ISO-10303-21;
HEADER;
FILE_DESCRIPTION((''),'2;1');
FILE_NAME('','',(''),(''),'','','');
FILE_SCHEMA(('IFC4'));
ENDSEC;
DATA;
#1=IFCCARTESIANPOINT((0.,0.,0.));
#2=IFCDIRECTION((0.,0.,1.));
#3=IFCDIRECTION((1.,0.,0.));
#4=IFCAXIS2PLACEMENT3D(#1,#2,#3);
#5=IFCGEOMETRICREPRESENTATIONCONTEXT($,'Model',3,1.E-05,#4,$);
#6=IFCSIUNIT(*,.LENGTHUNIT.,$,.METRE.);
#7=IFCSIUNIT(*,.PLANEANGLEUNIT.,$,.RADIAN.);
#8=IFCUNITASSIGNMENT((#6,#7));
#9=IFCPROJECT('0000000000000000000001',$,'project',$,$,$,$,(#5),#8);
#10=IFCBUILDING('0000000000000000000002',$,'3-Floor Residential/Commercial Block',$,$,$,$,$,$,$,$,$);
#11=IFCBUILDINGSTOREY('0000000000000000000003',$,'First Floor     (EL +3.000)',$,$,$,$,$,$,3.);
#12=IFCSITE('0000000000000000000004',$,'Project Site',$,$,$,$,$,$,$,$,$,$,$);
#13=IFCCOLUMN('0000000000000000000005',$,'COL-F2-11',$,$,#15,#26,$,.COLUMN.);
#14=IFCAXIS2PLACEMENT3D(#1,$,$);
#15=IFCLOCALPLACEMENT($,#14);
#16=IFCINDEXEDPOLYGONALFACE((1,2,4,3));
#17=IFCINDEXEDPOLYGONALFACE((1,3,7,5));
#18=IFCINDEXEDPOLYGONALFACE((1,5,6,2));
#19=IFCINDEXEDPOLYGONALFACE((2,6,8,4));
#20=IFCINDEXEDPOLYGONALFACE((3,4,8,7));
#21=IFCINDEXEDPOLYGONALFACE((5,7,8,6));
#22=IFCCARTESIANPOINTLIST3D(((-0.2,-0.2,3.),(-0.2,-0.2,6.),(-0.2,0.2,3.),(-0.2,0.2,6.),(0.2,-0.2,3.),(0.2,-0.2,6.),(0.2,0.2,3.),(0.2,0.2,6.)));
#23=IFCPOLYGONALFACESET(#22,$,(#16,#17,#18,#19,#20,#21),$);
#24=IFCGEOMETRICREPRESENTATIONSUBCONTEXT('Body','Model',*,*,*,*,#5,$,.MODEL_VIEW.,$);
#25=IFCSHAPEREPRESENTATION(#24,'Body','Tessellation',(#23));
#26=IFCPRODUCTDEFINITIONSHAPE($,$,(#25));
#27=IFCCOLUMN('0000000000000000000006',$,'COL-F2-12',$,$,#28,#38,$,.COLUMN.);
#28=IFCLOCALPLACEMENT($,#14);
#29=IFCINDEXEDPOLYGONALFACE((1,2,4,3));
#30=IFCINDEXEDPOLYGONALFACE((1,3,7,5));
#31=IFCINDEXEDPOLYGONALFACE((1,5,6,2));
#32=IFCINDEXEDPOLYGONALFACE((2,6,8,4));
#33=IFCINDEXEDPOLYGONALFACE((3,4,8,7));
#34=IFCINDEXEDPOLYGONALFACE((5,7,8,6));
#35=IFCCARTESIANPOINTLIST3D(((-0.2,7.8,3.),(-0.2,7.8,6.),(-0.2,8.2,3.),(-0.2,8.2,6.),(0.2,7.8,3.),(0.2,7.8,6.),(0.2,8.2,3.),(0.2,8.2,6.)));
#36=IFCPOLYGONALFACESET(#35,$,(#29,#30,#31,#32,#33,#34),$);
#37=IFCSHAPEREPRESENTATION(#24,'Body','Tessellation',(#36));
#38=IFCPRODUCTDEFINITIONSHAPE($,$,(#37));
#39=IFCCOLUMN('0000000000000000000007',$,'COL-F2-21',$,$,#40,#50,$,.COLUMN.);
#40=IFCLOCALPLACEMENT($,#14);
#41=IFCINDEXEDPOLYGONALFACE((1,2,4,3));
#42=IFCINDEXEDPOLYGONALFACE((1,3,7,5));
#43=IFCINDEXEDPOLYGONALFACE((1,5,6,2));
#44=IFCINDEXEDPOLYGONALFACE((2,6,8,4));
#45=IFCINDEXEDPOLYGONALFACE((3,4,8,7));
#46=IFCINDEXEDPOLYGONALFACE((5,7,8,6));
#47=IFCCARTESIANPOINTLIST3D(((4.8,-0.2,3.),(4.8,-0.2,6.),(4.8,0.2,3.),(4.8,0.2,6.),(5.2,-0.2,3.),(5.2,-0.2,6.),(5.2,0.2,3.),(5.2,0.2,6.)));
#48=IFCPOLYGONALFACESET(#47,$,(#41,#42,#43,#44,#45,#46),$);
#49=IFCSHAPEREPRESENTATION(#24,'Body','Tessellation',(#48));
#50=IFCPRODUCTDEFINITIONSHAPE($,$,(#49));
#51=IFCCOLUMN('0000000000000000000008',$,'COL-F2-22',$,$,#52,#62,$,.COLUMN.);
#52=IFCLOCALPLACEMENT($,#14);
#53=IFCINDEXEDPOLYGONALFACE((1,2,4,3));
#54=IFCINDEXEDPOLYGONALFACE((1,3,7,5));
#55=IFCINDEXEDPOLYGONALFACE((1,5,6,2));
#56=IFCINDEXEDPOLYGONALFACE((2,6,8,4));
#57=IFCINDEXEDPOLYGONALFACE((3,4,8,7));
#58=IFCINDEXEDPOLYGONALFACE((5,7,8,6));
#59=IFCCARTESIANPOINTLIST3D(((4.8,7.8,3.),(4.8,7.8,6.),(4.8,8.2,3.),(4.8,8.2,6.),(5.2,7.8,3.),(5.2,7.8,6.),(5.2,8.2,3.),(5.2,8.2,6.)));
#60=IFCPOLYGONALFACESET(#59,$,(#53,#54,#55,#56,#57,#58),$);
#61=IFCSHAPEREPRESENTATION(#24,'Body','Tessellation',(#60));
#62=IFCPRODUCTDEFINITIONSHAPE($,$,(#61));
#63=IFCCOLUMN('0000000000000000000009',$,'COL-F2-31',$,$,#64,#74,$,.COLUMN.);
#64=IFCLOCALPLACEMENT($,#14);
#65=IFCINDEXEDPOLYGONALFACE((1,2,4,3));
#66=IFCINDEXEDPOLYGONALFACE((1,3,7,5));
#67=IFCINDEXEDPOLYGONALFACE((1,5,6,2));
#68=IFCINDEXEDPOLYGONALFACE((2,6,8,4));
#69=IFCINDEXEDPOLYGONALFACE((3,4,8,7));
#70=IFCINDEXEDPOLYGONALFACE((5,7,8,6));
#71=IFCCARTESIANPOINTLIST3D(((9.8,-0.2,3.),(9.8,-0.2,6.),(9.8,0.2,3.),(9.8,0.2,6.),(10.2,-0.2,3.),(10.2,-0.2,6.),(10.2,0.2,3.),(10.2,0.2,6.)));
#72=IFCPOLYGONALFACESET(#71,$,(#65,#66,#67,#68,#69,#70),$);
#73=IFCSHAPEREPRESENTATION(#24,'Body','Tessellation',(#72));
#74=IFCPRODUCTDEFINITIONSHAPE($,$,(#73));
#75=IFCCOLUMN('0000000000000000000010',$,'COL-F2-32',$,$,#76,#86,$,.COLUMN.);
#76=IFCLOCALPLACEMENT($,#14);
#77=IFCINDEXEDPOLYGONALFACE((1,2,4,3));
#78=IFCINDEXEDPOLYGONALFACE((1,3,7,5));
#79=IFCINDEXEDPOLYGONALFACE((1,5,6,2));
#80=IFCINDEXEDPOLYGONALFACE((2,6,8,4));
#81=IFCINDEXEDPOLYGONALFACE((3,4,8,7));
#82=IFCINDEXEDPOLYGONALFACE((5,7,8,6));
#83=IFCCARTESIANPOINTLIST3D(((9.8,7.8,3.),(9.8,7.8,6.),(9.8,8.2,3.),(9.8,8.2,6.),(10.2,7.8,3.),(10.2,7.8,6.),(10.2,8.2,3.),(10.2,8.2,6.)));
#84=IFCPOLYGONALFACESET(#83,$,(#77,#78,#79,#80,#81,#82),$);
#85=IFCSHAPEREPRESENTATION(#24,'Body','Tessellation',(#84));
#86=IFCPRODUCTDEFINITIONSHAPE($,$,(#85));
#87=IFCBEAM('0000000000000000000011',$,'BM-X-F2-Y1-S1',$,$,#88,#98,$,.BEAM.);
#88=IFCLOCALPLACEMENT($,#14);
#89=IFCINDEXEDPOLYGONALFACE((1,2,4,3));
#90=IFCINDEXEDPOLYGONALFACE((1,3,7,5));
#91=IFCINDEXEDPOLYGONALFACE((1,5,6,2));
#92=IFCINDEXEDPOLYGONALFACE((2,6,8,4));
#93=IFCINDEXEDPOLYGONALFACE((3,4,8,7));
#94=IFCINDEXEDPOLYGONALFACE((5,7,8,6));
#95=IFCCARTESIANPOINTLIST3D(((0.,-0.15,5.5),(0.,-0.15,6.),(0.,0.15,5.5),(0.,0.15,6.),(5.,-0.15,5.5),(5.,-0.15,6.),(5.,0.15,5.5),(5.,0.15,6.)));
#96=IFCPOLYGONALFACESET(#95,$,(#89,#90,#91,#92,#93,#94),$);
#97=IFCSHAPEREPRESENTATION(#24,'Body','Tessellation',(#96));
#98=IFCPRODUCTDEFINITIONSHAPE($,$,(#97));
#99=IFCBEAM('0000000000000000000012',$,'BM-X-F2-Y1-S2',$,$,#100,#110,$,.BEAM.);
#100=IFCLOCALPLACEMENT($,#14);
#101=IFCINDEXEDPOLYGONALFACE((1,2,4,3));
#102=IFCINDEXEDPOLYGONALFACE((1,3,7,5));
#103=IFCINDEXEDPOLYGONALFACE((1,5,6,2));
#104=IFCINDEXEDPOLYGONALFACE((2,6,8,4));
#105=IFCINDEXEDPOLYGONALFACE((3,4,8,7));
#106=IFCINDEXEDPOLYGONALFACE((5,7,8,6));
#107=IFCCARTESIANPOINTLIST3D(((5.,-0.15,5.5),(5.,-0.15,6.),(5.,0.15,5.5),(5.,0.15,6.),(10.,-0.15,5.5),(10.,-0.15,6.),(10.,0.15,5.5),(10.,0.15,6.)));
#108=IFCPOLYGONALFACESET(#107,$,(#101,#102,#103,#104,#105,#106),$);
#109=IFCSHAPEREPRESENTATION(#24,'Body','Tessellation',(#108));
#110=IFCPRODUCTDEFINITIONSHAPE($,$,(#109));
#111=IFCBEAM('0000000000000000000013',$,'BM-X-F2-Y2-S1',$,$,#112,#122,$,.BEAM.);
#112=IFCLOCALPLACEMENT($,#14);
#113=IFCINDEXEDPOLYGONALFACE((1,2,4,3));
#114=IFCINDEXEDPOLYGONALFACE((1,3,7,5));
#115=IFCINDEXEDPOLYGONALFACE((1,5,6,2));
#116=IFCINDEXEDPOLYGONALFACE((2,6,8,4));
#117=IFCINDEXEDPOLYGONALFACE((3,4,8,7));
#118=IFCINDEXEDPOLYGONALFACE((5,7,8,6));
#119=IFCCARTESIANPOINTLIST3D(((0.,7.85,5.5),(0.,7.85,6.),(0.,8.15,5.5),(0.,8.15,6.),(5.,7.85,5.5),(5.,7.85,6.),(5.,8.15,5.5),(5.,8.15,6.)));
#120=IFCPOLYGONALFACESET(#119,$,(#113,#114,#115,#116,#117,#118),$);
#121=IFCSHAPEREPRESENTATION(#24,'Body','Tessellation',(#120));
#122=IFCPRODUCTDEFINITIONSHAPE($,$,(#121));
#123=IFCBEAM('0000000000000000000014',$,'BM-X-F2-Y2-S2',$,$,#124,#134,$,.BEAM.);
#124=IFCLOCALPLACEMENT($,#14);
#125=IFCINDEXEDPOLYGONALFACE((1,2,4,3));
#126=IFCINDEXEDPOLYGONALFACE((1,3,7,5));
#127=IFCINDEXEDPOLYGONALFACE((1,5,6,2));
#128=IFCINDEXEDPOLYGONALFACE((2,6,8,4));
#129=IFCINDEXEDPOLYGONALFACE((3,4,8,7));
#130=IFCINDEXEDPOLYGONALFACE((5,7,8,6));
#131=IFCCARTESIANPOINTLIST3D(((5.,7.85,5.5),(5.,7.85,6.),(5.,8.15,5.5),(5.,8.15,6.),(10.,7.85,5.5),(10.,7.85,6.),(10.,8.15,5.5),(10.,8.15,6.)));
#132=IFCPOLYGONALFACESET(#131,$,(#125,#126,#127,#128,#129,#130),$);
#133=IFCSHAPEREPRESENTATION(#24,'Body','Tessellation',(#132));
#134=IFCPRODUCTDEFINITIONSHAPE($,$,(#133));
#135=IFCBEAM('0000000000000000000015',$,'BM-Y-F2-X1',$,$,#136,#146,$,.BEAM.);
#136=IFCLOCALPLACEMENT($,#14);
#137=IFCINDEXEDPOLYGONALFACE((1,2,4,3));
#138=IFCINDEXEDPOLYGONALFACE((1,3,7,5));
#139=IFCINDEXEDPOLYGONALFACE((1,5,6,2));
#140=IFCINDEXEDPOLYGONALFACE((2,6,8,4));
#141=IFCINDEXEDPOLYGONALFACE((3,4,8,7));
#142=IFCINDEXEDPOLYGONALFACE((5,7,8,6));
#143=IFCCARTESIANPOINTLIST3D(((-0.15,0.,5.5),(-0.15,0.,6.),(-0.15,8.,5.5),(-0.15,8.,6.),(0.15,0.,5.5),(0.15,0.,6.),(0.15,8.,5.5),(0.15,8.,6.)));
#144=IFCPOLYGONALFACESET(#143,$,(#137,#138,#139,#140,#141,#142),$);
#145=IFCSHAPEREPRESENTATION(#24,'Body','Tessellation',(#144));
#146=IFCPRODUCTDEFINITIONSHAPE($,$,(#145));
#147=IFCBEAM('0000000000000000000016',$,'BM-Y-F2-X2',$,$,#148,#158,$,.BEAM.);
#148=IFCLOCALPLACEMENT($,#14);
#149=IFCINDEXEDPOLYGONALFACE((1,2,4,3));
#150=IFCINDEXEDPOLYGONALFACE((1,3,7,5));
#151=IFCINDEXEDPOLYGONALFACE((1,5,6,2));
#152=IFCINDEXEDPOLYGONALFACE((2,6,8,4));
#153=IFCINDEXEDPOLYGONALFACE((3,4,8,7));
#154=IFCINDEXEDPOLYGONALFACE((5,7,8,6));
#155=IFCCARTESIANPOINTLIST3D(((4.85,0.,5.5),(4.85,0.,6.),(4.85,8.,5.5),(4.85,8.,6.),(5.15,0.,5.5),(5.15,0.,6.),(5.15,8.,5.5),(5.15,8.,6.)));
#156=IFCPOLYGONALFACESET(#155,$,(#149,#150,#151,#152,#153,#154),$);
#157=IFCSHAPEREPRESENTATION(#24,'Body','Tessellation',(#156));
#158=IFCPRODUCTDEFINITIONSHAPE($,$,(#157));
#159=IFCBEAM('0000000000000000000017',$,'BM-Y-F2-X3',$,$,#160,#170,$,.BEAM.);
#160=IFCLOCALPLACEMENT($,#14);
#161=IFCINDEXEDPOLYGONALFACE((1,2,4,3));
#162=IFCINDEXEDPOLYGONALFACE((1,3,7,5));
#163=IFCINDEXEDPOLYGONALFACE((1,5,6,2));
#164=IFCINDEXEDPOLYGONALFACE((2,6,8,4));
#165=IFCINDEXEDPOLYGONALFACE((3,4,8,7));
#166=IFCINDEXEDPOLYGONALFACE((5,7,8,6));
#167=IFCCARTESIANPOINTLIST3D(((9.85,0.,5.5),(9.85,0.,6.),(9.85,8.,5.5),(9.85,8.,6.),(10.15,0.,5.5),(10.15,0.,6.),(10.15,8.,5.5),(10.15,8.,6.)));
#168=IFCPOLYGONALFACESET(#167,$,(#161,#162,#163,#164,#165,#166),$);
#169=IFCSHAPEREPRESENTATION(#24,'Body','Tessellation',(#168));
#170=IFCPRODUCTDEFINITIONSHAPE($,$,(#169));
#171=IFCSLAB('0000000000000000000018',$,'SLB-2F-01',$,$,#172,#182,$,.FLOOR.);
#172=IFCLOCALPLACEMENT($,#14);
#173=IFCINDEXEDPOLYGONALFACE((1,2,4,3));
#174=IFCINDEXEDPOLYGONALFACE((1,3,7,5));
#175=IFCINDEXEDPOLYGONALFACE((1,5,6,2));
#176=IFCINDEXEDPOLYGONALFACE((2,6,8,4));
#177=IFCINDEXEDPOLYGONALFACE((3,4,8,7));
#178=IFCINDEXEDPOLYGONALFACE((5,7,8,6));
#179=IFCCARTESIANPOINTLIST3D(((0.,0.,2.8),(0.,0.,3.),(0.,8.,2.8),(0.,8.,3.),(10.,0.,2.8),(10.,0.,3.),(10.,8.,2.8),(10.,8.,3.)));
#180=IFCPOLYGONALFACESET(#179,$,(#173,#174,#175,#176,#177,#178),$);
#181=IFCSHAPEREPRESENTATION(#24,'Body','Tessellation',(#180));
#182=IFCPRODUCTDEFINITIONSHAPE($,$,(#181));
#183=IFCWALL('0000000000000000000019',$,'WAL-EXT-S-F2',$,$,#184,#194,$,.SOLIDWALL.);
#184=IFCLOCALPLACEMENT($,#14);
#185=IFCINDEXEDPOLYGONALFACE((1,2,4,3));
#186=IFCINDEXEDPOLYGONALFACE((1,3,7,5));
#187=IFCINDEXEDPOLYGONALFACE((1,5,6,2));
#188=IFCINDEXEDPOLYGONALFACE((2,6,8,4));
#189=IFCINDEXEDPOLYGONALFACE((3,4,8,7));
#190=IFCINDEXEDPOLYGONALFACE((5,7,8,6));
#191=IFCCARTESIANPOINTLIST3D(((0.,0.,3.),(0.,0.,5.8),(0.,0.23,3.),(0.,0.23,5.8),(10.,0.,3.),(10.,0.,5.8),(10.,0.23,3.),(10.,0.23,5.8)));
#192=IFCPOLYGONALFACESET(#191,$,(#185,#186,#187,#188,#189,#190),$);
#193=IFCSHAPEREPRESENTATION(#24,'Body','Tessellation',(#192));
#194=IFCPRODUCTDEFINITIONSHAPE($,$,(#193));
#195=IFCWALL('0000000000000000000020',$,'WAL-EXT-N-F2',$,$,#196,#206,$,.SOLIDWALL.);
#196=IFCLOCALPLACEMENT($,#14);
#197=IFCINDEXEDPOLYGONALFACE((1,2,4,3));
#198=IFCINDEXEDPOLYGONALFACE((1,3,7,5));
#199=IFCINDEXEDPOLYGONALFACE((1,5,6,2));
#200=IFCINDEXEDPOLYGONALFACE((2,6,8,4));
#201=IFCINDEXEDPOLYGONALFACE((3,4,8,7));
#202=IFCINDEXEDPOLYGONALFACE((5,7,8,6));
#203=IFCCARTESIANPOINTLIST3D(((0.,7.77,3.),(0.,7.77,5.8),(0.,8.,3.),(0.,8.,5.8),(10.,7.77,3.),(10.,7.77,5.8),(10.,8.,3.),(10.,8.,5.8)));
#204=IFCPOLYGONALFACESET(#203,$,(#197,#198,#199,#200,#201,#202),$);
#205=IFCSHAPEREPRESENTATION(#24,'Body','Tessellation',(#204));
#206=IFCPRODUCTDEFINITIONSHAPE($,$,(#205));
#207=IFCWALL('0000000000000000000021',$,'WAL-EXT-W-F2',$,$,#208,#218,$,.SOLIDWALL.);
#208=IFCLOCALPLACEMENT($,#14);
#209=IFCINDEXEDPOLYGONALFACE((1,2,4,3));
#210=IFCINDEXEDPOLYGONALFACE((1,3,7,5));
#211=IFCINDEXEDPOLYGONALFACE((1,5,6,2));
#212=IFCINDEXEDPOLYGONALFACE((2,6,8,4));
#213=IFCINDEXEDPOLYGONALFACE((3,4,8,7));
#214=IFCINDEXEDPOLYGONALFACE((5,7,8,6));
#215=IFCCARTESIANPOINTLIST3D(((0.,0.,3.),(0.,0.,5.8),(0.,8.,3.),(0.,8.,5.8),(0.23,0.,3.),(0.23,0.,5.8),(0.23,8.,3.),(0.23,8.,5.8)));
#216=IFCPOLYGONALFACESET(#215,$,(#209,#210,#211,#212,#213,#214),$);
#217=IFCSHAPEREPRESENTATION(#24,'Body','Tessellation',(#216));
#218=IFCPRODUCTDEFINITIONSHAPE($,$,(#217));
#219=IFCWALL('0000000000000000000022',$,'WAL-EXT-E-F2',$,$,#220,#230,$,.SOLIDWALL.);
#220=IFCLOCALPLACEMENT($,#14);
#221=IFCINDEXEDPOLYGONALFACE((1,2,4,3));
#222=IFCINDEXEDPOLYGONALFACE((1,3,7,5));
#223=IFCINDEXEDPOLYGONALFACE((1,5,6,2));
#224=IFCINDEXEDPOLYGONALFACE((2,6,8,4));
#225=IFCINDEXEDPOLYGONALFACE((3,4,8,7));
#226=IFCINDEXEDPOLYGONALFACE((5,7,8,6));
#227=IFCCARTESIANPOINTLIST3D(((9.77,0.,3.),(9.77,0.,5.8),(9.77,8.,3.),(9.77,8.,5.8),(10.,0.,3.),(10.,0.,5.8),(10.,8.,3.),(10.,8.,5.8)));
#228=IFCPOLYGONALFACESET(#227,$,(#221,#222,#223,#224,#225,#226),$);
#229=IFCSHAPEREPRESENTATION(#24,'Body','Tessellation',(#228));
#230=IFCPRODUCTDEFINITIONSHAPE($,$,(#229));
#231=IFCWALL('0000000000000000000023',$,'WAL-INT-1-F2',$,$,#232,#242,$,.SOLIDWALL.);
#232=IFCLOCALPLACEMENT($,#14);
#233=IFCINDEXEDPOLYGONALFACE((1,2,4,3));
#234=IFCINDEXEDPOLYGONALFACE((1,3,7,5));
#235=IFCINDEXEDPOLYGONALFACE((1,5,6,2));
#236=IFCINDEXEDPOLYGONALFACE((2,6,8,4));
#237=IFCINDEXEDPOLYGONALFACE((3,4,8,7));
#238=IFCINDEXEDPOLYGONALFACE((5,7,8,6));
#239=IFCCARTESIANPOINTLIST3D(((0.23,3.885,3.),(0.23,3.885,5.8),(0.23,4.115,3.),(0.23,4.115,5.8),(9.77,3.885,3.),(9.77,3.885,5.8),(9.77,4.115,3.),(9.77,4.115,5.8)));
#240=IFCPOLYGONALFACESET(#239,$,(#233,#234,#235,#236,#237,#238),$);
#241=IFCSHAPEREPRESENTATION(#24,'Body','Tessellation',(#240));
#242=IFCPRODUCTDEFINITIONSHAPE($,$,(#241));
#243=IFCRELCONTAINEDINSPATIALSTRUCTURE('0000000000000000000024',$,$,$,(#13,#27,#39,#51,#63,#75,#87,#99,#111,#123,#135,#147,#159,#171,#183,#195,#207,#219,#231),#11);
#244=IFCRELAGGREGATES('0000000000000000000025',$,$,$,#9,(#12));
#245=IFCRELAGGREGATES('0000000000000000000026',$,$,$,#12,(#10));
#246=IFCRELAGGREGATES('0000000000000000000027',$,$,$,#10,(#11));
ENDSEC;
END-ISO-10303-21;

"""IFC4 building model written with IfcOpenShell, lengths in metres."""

from ifc_helpers import new_model, si_unit, frame, frame_2d, origin_with_axes, place, context, subcontext, project, spatial, rectangle, extrude, element, save


model = new_model("IFC4")

# Units and contexts
model_context = context("Model", 3, precision=1e-05, world=origin_with_axes())
body_context = subcontext(model_context, "Body", "Model", "MODEL_VIEW")
ifc_project = project(units=[si_unit("LENGTHUNIT", "METRE"), si_unit("PLANEANGLEUNIT", "RADIAN")], contexts=[model_context])

# Site, building, storey
site = spatial("IfcSite", under=ifc_project, Name="Project Site")
building = spatial("IfcBuilding", under=site, Name="3-Floor Residential/Commercial Block")
storey = spatial("IfcBuildingStorey", under=building, Name="First Floor     (EL +3.000)", Elevation=3.0)

# Columns
for number, where, z_axis, x_axis, name in (
    (1, (-0.2, -0.2, 3.0), (0.0, 0.0, 1.0), (1.0, 0.0, 0.0), "COL-F2-11"),
    (2, (-0.2, 7.8, 3.0), (0.0, 0.0, 1.0), (1.0, 0.0, 0.0), "COL-F2-12"),
    (3, (4.8, -0.2, 3.0), (0.0, 0.0, 1.0), (1.0, 0.0, 0.0), "COL-F2-21"),
    (4, (4.8, 7.8, 3.0), (0.0, 0.0, 1.0), (1.0, 0.0, 0.0), "COL-F2-22"),
    (5, (9.8, -0.2, 3.0), (0.0, 0.0, 1.0), (1.0, 0.0, 0.0), "COL-F2-31"),
    (6, (9.8, 7.8, 3.0), (0.0, 0.0, 1.0), (1.0, 0.0, 0.0), "COL-F2-32"),
):
    element("IfcColumn", number, at=place(None, frame(where, z_axis=z_axis, x_axis=x_axis)), inside=storey, Name=name, PredefinedType="COLUMN", context=body_context, shape_type="SweptSolid", body=[
        extrude(rectangle(XDim=0.4, YDim=0.4, at=frame_2d((0.2, 0.2))), origin_with_axes(), (0.0, 0.0, 1.0), 3.0),
    ])

# Beams
for number, where, z_axis, x_axis, name in (
    (7, (0.0, -0.15, 5.5), (0.0, 0.0, 1.0), (1.0, 0.0, 0.0), "BM-X-F2-Y1-S1"),
    (8, (5.0, -0.15, 5.5), (0.0, 0.0, 1.0), (1.0, 0.0, 0.0), "BM-X-F2-Y1-S2"),
    (9, (0.0, 7.85, 5.5), (0.0, 0.0, 1.0), (1.0, 0.0, 0.0), "BM-X-F2-Y2-S1"),
    (10, (5.0, 7.85, 5.5), (0.0, 0.0, 1.0), (1.0, 0.0, 0.0), "BM-X-F2-Y2-S2"),
):
    element("IfcBeam", number, at=place(None, frame(where, z_axis=z_axis, x_axis=x_axis)), inside=storey, Name=name, PredefinedType="BEAM", context=body_context, shape_type="SweptSolid", body=[
        extrude(rectangle(XDim=5.0, YDim=0.3, at=frame_2d((2.5, 0.15))), origin_with_axes(), (0.0, 0.0, 1.0), 0.5),
    ])
for number, where, z_axis, x_axis, name in (
    (11, (-0.15, 0.0, 5.5), (0.0, 0.0, 1.0), (1.0, 0.0, 0.0), "BM-Y-F2-X1"),
    (12, (4.85, 0.0, 5.5), (0.0, 0.0, 1.0), (1.0, 0.0, 0.0), "BM-Y-F2-X2"),
    (13, (9.85, 0.0, 5.5), (0.0, 0.0, 1.0), (1.0, 0.0, 0.0), "BM-Y-F2-X3"),
):
    element("IfcBeam", number, at=place(None, frame(where, z_axis=z_axis, x_axis=x_axis)), inside=storey, Name=name, PredefinedType="BEAM", context=body_context, shape_type="SweptSolid", body=[
        extrude(rectangle(XDim=0.3, YDim=8.0, at=frame_2d((0.15, 4.0))), origin_with_axes(), (0.0, 0.0, 1.0), 0.5),
    ])

# Slab
slab_placement = place(None, frame((0.0, 0.0, 2.8), z_axis=(0.0, 0.0, 1.0), x_axis=(1.0, 0.0, 0.0)))
element("IfcSlab", 14, at=slab_placement, inside=storey, Name="SLB-2F-01", PredefinedType="FLOOR", context=body_context, shape_type="SweptSolid", body=[
    extrude(rectangle(XDim=10.0, YDim=8.0, at=frame_2d((5.0, 4.0))), origin_with_axes(), (0.0, 0.0, 1.0), 0.2),
])

# Walls
for number, where, z_axis, x_axis, name in (
    (15, (0.0, 0.0, 3.0), (0.0, 0.0, 1.0), (1.0, 0.0, 0.0), "WAL-EXT-S-F2"),
    (16, (0.0, 7.77, 3.0), (0.0, 0.0, 1.0), (1.0, 0.0, 0.0), "WAL-EXT-N-F2"),
):
    element("IfcWall", number, at=place(None, frame(where, z_axis=z_axis, x_axis=x_axis)), inside=storey, Name=name, PredefinedType="SOLIDWALL", context=body_context, shape_type="SweptSolid", body=[
        extrude(rectangle(XDim=10.0, YDim=0.23, at=frame_2d((5.0, 0.115))), origin_with_axes(), (0.0, 0.0, 1.0), 2.8),
    ])
for number, where, z_axis, x_axis, name in (
    (17, (0.0, 0.0, 3.0), (0.0, 0.0, 1.0), (1.0, 0.0, 0.0), "WAL-EXT-W-F2"),
    (18, (9.77, 0.0, 3.0), (0.0, 0.0, 1.0), (1.0, 0.0, 0.0), "WAL-EXT-E-F2"),
):
    element("IfcWall", number, at=place(None, frame(where, z_axis=z_axis, x_axis=x_axis)), inside=storey, Name=name, PredefinedType="SOLIDWALL", context=body_context, shape_type="SweptSolid", body=[
        extrude(rectangle(XDim=0.23, YDim=8.0, at=frame_2d((0.115, 4.0))), origin_with_axes(), (0.0, 0.0, 1.0), 2.8),
    ])
wall_1_placement = place(None, frame((0.23, 3.885, 3.0), z_axis=(0.0, 0.0, 1.0), x_axis=(1.0, 0.0, 0.0)))
element("IfcWall", 19, at=wall_1_placement, inside=storey, Name="WAL-INT-1-F2", PredefinedType="SOLIDWALL", context=body_context, shape_type="SweptSolid", body=[
    extrude(rectangle(XDim=9.54, YDim=0.23, at=frame_2d((4.77, 0.115))), origin_with_axes(), (0.0, 0.0, 1.0), 2.8),
])

save(model, "model.ifc")
